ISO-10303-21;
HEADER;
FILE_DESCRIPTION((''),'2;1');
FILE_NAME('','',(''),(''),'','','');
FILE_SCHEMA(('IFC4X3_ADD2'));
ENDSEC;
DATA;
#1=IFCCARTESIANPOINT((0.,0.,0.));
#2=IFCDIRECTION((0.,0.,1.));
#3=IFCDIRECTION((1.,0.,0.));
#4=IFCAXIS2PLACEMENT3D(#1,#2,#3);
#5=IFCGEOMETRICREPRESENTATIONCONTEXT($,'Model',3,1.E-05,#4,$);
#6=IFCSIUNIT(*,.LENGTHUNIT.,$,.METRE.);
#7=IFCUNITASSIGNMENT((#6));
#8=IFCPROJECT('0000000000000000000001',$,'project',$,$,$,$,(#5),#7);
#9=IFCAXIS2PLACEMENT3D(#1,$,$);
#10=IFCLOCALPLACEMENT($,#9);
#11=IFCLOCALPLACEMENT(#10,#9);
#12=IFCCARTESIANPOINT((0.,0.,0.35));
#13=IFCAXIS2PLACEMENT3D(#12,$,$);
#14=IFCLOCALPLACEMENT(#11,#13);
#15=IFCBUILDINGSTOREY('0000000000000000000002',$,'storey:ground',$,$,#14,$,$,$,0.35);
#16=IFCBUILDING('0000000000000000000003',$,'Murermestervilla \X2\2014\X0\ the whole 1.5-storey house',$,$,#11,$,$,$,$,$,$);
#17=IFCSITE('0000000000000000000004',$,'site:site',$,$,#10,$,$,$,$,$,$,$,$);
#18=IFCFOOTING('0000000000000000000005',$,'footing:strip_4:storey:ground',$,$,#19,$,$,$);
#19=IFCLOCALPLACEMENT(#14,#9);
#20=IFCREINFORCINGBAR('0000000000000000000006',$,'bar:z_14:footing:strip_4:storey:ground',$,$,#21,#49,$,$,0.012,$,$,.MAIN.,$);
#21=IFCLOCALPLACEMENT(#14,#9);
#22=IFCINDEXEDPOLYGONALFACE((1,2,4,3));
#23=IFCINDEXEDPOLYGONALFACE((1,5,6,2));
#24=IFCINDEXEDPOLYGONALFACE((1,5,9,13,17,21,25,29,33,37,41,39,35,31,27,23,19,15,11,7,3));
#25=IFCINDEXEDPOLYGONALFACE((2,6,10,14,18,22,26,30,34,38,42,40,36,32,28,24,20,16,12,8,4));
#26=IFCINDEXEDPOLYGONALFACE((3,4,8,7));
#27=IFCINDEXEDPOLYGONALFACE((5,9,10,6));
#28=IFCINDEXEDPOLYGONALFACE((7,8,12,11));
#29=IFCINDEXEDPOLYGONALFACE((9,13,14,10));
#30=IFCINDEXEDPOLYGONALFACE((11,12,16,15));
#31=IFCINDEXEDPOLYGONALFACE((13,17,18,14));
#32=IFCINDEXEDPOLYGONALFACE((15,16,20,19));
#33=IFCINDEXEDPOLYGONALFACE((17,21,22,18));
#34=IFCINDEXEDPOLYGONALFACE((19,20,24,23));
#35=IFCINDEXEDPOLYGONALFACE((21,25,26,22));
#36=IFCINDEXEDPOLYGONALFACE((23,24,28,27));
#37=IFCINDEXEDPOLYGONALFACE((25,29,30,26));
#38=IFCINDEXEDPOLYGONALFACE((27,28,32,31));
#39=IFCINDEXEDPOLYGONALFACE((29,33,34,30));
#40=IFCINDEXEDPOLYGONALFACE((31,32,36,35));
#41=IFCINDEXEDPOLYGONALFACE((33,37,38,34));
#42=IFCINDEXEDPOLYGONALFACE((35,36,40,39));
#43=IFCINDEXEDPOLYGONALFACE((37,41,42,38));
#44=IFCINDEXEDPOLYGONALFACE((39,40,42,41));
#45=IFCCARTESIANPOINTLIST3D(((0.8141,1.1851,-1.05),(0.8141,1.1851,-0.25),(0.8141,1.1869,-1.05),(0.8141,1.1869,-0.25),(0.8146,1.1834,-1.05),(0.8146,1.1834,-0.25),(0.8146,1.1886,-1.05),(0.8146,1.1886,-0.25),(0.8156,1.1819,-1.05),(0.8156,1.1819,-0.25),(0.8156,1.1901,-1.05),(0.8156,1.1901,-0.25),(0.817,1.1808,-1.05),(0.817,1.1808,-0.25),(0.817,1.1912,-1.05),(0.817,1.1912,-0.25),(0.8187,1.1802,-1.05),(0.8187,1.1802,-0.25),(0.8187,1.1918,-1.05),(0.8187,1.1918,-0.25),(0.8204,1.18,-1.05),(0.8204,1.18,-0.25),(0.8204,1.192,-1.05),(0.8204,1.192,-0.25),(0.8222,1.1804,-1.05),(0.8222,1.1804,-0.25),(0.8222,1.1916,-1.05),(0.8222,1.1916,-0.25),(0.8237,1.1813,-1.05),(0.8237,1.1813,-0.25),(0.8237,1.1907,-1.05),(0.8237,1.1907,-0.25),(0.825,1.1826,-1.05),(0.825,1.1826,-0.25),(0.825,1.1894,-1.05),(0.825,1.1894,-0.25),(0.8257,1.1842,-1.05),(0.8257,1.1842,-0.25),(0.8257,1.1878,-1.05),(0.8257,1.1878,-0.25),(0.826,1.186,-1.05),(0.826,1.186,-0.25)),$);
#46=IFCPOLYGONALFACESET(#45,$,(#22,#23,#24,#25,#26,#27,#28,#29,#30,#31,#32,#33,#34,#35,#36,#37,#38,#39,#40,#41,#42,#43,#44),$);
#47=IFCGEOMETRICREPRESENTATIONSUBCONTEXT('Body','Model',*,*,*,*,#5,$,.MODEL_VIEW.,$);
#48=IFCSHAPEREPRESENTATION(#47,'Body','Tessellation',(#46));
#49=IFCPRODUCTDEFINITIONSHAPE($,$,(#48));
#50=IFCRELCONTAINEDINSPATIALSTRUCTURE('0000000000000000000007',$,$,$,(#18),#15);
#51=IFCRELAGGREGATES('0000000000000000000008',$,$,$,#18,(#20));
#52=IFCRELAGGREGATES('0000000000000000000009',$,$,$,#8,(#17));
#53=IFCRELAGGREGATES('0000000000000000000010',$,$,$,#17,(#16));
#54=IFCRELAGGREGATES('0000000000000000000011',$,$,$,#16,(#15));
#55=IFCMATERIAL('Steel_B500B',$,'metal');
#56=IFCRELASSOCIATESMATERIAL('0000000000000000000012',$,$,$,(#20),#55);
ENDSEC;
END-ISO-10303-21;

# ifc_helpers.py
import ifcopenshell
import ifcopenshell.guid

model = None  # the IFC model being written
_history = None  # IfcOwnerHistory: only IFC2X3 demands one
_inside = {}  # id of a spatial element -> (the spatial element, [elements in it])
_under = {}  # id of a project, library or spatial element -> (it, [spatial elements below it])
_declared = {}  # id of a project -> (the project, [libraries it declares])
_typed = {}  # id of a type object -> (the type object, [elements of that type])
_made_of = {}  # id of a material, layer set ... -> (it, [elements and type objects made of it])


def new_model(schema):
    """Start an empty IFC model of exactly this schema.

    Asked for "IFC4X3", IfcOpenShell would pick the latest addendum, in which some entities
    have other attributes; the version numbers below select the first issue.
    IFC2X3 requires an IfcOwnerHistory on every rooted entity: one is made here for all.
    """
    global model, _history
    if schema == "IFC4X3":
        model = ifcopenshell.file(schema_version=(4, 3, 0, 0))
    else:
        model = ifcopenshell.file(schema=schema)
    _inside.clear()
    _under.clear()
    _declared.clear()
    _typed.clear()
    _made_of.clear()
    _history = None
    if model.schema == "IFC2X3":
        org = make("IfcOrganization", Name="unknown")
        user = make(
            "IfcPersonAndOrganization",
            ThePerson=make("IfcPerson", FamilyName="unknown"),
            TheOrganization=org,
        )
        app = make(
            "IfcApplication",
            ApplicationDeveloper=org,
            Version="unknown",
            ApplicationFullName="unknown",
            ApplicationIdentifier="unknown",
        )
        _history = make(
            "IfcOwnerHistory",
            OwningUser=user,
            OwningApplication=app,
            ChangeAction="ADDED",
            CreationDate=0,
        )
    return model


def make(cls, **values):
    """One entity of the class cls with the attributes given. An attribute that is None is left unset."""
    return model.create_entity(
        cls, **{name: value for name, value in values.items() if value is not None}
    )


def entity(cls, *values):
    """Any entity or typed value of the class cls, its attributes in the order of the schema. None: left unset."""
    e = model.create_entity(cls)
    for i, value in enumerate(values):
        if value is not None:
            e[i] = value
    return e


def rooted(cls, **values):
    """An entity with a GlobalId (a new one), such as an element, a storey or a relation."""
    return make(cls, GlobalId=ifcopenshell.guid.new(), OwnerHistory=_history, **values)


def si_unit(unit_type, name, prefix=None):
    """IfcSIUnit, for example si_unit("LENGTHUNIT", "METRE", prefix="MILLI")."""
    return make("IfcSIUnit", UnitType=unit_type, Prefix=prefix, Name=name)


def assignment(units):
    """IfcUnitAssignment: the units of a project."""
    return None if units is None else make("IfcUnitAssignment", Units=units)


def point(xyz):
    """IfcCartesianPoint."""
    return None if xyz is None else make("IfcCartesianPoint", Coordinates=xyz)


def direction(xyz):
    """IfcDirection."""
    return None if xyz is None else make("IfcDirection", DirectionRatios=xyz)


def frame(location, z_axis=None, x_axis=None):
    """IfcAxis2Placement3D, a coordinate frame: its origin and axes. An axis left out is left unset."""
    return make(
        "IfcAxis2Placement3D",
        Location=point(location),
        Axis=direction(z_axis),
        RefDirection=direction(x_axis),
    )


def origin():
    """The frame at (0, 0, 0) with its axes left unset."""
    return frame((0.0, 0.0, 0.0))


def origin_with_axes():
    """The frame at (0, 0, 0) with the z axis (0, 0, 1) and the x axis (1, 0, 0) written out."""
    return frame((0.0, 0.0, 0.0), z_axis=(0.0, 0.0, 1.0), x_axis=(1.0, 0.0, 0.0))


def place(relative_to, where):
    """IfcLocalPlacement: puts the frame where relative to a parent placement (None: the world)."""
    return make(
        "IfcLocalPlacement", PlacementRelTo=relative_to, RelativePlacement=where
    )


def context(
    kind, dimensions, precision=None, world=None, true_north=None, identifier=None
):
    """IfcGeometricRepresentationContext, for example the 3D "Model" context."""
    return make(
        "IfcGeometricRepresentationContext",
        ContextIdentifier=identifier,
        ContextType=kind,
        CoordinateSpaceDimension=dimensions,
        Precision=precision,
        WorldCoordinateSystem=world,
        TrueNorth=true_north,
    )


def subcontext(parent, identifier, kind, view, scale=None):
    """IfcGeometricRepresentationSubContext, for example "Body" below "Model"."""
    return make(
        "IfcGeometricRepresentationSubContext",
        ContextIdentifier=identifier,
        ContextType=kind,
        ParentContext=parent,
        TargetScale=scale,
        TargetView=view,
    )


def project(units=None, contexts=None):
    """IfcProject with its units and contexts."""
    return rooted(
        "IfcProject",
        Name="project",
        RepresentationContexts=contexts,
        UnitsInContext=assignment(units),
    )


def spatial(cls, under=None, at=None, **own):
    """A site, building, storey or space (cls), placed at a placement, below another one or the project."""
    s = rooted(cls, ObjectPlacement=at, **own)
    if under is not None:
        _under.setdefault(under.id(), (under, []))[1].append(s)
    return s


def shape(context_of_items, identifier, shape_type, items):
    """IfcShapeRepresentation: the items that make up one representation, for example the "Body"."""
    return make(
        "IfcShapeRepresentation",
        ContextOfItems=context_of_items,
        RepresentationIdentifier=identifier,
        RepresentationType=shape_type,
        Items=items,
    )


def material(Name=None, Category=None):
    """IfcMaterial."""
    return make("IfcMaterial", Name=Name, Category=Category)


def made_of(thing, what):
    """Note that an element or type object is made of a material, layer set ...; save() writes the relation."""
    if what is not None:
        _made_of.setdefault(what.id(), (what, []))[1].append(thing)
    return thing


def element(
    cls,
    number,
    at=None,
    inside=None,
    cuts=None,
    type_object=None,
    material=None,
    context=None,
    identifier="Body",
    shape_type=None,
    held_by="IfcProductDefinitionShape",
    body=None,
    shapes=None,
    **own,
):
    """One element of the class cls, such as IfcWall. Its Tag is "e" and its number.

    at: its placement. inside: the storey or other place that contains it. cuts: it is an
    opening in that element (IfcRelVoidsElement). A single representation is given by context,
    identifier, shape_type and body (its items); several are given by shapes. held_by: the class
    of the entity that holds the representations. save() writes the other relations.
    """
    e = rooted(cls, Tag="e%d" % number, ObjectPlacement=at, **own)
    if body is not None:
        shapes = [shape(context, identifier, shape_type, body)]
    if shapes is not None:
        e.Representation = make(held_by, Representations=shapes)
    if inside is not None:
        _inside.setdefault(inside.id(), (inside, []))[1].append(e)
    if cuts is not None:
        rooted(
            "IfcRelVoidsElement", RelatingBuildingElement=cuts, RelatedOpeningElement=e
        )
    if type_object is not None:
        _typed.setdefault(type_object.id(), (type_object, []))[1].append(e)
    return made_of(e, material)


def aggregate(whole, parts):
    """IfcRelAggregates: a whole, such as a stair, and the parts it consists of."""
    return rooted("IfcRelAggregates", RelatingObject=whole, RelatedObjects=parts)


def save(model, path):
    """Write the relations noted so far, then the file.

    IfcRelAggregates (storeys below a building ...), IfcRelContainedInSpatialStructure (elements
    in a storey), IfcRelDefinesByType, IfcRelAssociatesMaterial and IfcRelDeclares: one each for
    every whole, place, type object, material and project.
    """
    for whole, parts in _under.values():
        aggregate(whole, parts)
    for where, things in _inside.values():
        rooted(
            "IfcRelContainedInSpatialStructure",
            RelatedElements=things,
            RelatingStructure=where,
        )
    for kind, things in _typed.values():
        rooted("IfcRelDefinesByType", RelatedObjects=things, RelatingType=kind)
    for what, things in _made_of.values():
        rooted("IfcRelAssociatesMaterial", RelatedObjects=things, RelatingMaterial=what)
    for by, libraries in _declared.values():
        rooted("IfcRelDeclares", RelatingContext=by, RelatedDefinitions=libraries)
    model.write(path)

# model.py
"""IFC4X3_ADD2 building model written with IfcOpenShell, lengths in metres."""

from ifc_helpers import new_model, entity, si_unit, frame, origin, origin_with_axes, place, context, subcontext, project, spatial, material, element, aggregate, save


model = new_model("IFC4X3_ADD2")

# Units and contexts
model_context = context("Model", 3, precision=1e-05, world=origin_with_axes())
body_context = subcontext(model_context, "Body", "Model", "MODEL_VIEW")
ifc_project = project(units=[si_unit("LENGTHUNIT", "METRE")], contexts=[model_context])

# Site, building, storey
placement_1 = place(None, origin())
site = spatial("IfcSite", under=ifc_project, at=placement_1, Name="site:site")
building_placement = place(placement_1, origin())
building = spatial("IfcBuilding", under=site, at=building_placement, Name="Murermestervilla — the whole 1.5-storey house")
storey_placement = place(building_placement, frame((0.0, 0.0, 0.35)))
storey = spatial("IfcBuildingStorey", under=building, at=storey_placement, Name="storey:ground", Elevation=0.35)

# Footing, reinforcing bar
placement_2 = place(storey_placement, frame((0.0, 0.0, -0.35)))
ifc_material = material(Name="Steel_B500B", Category="metal")
footing_1 = element("IfcFooting", 1, at=placement_2, inside=storey, Name="footing:strip_4:storey:ground")
reinforcing_bar_1 = element("IfcReinforcingBar", 2, at=placement_1, material=ifc_material, Name="bar:z_14:footing:strip_4:storey:ground", NominalDiameter=0.012, PredefinedType="MAIN", context=body_context, shape_type="AdvancedSweptSolid", body=[
    entity("IfcSweptDiskSolid", entity("IfcPolyline", [entity("IfcCartesianPoint", [0.82, 1.186, -0.7]), entity("IfcCartesianPoint", [0.82, 1.186, 0.1])]), 0.006),
])
aggregate(footing_1, [reinforcing_bar_1])

save(model, "model.ifc")
